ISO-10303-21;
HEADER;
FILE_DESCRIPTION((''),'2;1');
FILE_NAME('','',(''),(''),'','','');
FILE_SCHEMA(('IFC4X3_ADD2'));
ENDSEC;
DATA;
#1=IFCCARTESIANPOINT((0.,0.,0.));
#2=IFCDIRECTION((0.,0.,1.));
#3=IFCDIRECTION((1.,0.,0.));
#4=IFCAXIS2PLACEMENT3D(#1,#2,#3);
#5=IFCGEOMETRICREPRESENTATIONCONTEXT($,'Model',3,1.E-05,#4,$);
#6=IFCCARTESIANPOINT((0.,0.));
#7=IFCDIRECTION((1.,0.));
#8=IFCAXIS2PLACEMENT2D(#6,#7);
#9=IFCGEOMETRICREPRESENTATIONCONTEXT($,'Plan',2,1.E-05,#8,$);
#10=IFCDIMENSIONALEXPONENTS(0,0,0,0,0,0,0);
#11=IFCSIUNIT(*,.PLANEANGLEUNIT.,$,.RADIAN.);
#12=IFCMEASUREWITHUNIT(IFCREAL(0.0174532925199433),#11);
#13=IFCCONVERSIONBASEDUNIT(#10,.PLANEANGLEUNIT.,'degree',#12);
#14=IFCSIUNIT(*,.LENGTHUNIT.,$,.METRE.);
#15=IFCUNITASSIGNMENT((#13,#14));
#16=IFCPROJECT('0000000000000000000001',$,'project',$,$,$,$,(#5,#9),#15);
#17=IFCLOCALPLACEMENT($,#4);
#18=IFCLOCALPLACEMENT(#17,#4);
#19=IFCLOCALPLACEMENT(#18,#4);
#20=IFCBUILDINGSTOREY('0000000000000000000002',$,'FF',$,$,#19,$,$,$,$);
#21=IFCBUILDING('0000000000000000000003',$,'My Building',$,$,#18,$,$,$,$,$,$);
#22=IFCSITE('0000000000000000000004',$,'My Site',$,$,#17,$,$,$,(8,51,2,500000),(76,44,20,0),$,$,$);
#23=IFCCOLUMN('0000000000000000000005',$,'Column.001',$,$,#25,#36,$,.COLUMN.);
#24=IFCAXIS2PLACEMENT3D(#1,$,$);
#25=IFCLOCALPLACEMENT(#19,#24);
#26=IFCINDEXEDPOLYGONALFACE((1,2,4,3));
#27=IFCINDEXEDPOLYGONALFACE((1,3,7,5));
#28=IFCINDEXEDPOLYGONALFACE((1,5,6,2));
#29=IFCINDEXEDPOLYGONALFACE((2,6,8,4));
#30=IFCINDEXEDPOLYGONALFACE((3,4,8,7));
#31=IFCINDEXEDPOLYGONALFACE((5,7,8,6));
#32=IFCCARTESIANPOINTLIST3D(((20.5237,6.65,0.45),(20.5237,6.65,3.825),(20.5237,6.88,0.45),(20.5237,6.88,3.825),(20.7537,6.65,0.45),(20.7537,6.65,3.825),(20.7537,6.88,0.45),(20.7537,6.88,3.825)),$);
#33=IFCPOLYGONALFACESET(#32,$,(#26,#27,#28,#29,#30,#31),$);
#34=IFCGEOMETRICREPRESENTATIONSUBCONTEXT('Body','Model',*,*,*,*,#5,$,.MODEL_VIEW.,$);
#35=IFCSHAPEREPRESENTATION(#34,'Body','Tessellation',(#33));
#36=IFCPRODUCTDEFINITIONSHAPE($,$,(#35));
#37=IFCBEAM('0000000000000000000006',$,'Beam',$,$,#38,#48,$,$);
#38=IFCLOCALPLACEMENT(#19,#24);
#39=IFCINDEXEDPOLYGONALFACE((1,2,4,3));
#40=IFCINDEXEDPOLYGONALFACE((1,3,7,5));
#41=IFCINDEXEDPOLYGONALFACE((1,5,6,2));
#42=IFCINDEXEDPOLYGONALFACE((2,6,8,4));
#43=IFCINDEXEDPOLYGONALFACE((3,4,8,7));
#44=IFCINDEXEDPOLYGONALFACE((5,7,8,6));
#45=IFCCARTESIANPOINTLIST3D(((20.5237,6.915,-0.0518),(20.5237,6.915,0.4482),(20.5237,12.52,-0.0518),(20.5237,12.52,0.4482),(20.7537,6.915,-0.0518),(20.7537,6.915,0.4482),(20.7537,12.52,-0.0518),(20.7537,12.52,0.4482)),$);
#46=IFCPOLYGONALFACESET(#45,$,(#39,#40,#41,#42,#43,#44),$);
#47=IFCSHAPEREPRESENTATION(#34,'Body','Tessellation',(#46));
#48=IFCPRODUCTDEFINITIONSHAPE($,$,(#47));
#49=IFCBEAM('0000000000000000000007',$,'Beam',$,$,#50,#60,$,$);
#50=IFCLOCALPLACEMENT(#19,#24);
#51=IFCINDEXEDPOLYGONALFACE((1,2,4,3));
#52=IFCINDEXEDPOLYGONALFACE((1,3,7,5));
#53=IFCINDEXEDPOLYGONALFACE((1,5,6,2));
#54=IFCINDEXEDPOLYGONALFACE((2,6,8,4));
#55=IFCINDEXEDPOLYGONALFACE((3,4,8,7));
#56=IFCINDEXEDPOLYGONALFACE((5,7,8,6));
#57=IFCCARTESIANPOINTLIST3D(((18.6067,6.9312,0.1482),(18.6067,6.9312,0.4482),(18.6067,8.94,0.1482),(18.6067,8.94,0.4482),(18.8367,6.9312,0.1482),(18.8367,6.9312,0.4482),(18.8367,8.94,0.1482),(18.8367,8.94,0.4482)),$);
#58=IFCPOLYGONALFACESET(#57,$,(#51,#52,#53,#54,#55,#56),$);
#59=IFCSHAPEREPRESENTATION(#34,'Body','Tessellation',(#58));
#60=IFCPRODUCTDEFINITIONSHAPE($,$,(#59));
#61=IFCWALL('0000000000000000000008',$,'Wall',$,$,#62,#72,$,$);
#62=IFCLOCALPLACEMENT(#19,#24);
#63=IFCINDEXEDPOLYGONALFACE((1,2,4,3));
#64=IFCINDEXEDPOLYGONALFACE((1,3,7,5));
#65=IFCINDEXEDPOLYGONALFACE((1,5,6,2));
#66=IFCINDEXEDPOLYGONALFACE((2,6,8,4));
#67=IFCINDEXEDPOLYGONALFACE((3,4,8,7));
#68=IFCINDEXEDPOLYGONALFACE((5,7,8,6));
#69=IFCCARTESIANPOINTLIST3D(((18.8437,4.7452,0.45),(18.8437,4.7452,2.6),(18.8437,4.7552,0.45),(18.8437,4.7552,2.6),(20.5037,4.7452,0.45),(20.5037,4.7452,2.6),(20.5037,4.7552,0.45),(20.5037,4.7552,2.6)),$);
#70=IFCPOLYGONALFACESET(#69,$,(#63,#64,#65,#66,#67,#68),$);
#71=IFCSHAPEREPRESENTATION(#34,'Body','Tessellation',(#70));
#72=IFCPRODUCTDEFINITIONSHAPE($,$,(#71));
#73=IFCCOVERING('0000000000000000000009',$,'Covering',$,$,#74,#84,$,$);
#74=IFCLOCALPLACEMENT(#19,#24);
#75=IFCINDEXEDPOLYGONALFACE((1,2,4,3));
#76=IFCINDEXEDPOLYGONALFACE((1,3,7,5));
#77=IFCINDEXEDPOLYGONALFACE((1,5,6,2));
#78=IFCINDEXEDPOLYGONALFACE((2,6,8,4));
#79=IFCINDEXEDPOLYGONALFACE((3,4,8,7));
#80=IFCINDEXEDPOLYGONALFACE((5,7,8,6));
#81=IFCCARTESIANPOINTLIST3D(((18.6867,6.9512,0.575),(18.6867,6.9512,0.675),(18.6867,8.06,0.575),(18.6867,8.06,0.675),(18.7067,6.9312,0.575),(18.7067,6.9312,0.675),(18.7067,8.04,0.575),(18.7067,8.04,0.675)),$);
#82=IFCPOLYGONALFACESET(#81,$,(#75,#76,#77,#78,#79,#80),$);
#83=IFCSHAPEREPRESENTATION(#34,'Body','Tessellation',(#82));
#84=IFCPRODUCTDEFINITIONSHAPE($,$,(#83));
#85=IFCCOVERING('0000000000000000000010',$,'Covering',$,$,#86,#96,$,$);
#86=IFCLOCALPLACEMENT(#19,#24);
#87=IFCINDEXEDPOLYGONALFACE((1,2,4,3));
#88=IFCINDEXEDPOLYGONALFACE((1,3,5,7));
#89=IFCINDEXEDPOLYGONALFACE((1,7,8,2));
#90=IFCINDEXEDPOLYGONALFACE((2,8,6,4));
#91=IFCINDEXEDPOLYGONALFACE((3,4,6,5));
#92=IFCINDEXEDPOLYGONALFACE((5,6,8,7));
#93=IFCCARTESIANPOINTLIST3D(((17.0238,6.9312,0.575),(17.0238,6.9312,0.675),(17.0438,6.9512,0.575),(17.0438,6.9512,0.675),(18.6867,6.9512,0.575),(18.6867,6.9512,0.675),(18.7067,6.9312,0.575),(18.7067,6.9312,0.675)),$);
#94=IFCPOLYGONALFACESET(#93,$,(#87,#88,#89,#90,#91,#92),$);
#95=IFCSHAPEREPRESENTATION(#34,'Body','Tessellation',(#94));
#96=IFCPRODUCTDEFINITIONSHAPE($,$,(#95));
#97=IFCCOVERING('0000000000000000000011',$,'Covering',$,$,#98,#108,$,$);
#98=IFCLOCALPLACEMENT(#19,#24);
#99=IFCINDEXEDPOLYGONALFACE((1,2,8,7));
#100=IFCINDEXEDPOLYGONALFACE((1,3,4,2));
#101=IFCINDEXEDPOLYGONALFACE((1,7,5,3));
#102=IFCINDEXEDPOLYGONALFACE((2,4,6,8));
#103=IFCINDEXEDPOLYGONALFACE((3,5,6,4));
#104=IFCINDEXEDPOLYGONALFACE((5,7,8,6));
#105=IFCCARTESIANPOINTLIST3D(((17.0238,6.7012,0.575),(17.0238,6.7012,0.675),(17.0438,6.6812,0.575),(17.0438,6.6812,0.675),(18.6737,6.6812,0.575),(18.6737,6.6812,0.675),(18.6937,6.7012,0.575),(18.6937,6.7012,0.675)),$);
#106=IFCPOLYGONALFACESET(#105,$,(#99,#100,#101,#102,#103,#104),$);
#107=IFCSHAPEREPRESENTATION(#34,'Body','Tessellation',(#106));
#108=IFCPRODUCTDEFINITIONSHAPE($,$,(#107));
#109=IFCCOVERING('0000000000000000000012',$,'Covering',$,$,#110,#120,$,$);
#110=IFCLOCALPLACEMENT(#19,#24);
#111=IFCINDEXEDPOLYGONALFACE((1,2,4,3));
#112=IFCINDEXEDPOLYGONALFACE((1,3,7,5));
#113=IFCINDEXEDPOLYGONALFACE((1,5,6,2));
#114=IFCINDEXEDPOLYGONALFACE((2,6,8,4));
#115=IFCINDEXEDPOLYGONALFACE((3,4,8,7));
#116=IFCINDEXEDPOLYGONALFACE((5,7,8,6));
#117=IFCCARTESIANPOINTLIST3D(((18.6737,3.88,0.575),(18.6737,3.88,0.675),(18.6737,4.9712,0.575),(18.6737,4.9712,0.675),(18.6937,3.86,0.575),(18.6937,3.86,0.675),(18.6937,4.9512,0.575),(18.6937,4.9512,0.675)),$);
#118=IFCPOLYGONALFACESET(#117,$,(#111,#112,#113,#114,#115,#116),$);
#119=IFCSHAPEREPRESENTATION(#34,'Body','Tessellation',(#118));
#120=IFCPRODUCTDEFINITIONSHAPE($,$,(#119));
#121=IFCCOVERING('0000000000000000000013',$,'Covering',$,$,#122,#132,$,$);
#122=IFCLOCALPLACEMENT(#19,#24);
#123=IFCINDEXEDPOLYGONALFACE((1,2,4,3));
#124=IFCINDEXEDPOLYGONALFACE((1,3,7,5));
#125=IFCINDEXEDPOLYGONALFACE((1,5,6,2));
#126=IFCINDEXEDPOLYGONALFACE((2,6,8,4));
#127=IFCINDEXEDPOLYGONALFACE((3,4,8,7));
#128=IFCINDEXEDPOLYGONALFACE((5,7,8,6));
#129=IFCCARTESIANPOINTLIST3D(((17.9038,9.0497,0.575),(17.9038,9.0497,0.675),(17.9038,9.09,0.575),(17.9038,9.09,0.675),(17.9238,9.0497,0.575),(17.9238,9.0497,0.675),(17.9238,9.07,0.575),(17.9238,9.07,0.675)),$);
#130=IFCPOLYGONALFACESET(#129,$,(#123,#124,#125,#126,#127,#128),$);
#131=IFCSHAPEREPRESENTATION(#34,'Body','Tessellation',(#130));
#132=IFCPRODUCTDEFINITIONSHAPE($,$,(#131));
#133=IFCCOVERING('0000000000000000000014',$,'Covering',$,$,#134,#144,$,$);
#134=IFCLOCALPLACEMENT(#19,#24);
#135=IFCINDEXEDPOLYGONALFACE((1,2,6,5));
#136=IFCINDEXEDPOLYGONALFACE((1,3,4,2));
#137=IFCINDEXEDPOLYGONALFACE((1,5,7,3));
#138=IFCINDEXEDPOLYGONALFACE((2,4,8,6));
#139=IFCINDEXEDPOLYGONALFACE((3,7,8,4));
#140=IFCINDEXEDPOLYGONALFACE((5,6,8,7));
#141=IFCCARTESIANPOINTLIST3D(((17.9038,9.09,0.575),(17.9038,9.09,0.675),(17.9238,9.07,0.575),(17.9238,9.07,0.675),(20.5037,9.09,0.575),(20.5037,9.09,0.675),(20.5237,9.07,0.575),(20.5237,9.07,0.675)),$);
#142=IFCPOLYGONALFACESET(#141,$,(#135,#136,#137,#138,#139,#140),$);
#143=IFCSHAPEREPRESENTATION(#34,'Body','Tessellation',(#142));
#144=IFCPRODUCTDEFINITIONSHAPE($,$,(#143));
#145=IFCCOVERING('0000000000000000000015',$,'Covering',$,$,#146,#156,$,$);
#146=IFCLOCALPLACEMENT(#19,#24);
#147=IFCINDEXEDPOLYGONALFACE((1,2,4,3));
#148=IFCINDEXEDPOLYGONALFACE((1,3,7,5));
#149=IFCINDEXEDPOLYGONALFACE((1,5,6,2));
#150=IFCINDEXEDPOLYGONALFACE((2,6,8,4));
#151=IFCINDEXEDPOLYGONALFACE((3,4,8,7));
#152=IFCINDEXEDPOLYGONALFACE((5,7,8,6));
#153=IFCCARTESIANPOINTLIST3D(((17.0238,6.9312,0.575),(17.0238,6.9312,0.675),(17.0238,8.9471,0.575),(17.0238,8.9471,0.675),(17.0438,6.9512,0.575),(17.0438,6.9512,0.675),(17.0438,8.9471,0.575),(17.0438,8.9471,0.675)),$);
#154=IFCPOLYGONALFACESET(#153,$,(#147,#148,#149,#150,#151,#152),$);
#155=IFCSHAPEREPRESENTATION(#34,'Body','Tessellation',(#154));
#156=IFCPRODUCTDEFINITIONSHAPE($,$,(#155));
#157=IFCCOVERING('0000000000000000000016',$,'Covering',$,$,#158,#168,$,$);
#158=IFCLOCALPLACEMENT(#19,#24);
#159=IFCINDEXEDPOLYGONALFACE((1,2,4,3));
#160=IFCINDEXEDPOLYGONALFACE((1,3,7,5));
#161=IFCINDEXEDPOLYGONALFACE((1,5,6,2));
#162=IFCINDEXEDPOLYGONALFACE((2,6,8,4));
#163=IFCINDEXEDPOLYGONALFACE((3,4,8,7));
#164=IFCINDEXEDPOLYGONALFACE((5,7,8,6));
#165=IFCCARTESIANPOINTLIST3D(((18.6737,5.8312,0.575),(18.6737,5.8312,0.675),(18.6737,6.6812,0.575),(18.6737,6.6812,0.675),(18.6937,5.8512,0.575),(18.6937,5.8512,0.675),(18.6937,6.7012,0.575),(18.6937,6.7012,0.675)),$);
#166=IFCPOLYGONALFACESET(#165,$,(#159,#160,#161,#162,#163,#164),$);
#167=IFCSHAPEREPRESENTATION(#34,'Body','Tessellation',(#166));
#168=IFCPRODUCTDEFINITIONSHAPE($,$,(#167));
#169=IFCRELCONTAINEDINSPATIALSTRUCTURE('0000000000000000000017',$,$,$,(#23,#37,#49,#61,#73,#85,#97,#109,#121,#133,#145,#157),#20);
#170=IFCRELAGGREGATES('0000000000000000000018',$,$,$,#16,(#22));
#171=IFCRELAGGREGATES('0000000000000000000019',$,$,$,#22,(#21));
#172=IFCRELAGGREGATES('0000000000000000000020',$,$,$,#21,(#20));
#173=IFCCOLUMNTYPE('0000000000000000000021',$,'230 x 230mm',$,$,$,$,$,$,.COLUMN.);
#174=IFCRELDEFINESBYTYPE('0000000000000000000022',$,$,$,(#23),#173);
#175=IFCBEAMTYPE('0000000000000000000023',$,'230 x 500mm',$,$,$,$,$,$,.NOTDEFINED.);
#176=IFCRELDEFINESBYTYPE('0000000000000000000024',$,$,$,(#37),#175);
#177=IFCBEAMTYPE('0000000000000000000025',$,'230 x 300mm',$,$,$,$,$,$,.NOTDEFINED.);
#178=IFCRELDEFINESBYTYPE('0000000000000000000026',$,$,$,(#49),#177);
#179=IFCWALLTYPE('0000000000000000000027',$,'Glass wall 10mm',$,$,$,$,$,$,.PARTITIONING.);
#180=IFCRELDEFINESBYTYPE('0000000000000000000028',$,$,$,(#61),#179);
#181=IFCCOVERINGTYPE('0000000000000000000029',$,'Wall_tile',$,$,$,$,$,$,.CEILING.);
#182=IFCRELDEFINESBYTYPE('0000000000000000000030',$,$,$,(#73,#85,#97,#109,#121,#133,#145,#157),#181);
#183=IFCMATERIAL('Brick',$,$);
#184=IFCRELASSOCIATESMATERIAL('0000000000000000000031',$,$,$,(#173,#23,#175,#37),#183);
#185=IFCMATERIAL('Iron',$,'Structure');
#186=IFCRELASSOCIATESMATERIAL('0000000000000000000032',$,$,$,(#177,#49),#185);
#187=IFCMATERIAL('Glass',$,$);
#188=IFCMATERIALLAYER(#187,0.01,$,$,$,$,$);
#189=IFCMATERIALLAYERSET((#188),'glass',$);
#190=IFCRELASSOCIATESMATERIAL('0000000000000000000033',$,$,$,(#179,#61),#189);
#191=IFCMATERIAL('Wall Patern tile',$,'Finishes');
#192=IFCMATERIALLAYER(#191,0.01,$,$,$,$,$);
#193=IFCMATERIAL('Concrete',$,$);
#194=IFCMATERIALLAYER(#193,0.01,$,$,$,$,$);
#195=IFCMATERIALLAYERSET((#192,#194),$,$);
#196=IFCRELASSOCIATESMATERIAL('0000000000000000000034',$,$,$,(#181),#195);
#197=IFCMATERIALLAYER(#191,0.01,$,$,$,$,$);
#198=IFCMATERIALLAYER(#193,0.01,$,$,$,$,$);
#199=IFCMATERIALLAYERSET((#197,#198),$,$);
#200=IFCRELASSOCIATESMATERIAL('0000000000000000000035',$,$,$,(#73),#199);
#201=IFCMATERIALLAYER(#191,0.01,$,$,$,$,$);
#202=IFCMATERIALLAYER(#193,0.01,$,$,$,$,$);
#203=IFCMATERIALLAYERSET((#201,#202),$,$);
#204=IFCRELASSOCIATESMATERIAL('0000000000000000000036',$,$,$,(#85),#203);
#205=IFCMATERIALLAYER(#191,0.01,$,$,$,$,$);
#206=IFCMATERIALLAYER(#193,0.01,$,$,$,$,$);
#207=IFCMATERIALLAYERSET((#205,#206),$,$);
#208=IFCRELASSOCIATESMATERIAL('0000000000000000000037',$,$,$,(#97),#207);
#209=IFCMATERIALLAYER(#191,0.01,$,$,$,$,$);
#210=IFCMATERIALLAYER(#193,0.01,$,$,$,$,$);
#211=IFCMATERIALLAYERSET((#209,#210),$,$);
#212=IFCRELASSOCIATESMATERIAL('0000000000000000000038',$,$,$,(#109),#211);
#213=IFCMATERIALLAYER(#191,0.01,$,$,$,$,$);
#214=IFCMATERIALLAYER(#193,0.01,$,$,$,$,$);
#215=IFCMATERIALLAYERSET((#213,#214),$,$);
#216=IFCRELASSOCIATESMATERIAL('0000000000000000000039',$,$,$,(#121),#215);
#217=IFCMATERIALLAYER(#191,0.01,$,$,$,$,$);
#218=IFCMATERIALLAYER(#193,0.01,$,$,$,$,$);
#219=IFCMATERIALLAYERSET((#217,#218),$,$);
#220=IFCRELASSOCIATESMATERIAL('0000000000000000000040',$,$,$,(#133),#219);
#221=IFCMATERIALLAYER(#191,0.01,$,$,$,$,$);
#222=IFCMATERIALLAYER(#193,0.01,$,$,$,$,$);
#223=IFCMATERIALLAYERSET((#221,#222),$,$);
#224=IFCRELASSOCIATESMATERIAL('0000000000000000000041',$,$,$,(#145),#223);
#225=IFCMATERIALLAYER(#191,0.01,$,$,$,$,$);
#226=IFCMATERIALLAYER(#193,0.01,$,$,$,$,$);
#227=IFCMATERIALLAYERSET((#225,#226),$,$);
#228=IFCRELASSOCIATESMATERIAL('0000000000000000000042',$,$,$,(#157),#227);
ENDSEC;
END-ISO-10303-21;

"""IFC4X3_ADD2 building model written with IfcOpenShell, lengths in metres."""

from ifc_helpers import new_model, entity, si_unit, converted_unit, frame, origin_with_axes, origin_2d_with_axis, place, context, subcontext, project, spatial, line, indexed_curve, rectangle, outline, extrude, material, layer, layer_set, layer_usage, material_profile, profile_set, profile_usage, type_object, element, save


model = new_model("IFC4X3_ADD2")

# Units and contexts
model_context = context("Model", 3, precision=1e-05, world=origin_with_axes())
plan_context = context("Plan", 2, precision=1e-05, world=origin_2d_with_axis())
body_context_1 = subcontext(model_context, "Body", "Model", "MODEL_VIEW")
ifc_project = project(units=[converted_unit("PLANEANGLEUNIT", "degree", entity("IfcReal", 0.0174532925199433), si_unit("PLANEANGLEUNIT", "RADIAN"), dimensions=[0, 0, 0, 0, 0, 0, 0]), si_unit("LENGTHUNIT", "METRE")], contexts=[model_context, plan_context])

# Site, building, storey
site_placement = place(None, origin_with_axes())
site = spatial("IfcSite", under=ifc_project, at=site_placement, Name="My Site", RefLatitude=(8, 51, 2, 500000), RefLongitude=(76, 44, 20, 0))
building_placement = place(site_placement, origin_with_axes())
building = spatial("IfcBuilding", under=site, at=building_placement, Name="My Building")
storey_placement = place(building_placement, origin_with_axes())
storey = spatial("IfcBuildingStorey", under=building, at=storey_placement, Name="FF")

# Column
ifc_material_1 = material(Name="Brick")
ifc_material_profile_1 = material_profile(ifc_material_1, outline(indexed_curve([(-0.115, 0.115), (0.115, 0.115), (0.115, -0.115), (-0.115, -0.115), (-0.115, 0.115)])))
ifc_profile_set_1 = profile_set([ifc_material_profile_1])
ifc_profile_usage_1 = profile_usage(ifc_profile_set_1)
column_type = type_object("IfcColumnType", Name="230 x 230mm", PredefinedType="COLUMN", material=ifc_profile_set_1)
column_placement = place(storey_placement, frame((20.6387, 6.765, 0.45), z_axis=(0.0, 0.0, 1.0), x_axis=(1.0, 0.0, 0.0)))
element("IfcColumn", 1, at=column_placement, inside=storey, type_object=column_type, material=ifc_profile_usage_1, Name="Column.001", PredefinedType="COLUMN", context=body_context_1, shape_type="SweptSolid", body=[
    extrude(outline(indexed_curve([(-0.115, 0.115), (0.115, 0.115), (0.115, -0.115), (-0.115, -0.115), (-0.115, 0.115)])), origin_with_axes(), (0.0, 0.0, 1.0), 3.375),
])

# Beams
ifc_material_profile_2 = material_profile(ifc_material_1, rectangle(XDim=0.23, YDim=0.5))
ifc_profile_set_2 = profile_set([ifc_material_profile_2], Name="rcc")
ifc_profile_usage_2 = profile_usage(ifc_profile_set_2)
beam_type_1 = type_object("IfcBeamType", Name="230 x 500mm", PredefinedType="NOTDEFINED", material=ifc_profile_set_2)
beam_1_placement = place(storey_placement, frame((20.6387, 6.915, 0.1982), z_axis=(0.0, 1.0, 0.0), x_axis=(-1.0, 0.0, 0.0)))
element("IfcBeam", 2, at=beam_1_placement, inside=storey, type_object=beam_type_1, material=ifc_profile_usage_2, Name="Beam", context=body_context_1, shape_type="SweptSolid", body=[
    extrude(rectangle(XDim=0.23, YDim=0.5), origin_with_axes(), (0.0, 0.0, 1.0), 5.605),
])
ifc_material_2 = material(Name="Iron", Category="Structure")
ifc_material_profile_3 = material_profile(ifc_material_2, rectangle(XDim=0.23, YDim=0.3))
ifc_profile_set_3 = profile_set([ifc_material_profile_3], Name="blank")
ifc_profile_usage_3 = profile_usage(ifc_profile_set_3)
beam_type_2 = type_object("IfcBeamType", Name="230 x 300mm", PredefinedType="NOTDEFINED", material=ifc_profile_set_3)
beam_2_placement = place(storey_placement, frame((18.7217, 6.9312, 0.2982), z_axis=(0.0, 1.0, 0.0), x_axis=(-1.0, 0.0, 0.0)))
element("IfcBeam", 3, at=beam_2_placement, inside=storey, type_object=beam_type_2, material=ifc_profile_usage_3, Name="Beam", context=body_context_1, shape_type="SweptSolid", body=[
    extrude(rectangle(XDim=0.23, YDim=0.3), origin_with_axes(), (0.0, 0.0, 1.0), 2.0088),
])

# Shared definitions
ifc_material_3 = material(Name="Glass")

# Wall
ifc_layer_1 = layer(ifc_material_3, 0.01)
ifc_layer_set_1 = layer_set([ifc_layer_1], Name="glass")
ifc_layer_usage_1 = layer_usage(ifc_layer_set_1, "AXIS2", "POSITIVE", 0.0)
wall_type_1 = type_object("IfcWallType", Name="Glass wall 10mm", PredefinedType="PARTITIONING", material=ifc_layer_set_1)
wall_1_placement = place(storey_placement, frame((20.5037, 4.7552, 0.45), z_axis=(0.0, 0.0, 1.0), x_axis=(-1.0, 0.0, 0.0)))
element("IfcWall", 4, at=wall_1_placement, inside=storey, type_object=wall_type_1, material=ifc_layer_usage_1, Name="Wall", context=body_context_1, shape_type="SweptSolid", body=[
    extrude(outline(indexed_curve([(0.0, 0.0), (0.0, 0.01), (1.66, 0.01), (1.66, 0.0)], segments=[line(1, 2, 3, 4, 1)])), origin_with_axes(), (0.0, 0.0, 1.0), 2.15),
])

# Coverings
ifc_material_4 = material(Name="Wall Patern tile", Category="Finishes")
ifc_layer_2 = layer(ifc_material_4, 0.01)
ifc_material_5 = material(Name="Concrete")
ifc_layer_3 = layer(ifc_material_5, 0.01)
ifc_layer_set_2 = layer_set([ifc_layer_2, ifc_layer_3])
ifc_layer_usage_2 = layer_usage(ifc_layer_set_2, "AXIS2", "POSITIVE", 0.0)
ifc_layer_4 = layer(ifc_material_4, 0.01)
ifc_layer_5 = layer(ifc_material_5, 0.01)
ifc_layer_set_3 = layer_set([ifc_layer_4, ifc_layer_5])
covering_type_1 = type_object("IfcCoveringType", Name="Wall_tile", PredefinedType="CEILING", material=ifc_layer_set_3)
covering_1_placement = place(storey_placement, frame((18.6867, 8.04, 0.575), z_axis=(0.0, 0.0, 1.0), x_axis=(0.0, -1.0, 0.0)))
element("IfcCovering", 5, at=covering_1_placement, inside=storey, type_object=covering_type_1, material=ifc_layer_usage_2, Name="Covering", context=body_context_1, shape_type="SweptSolid", body=[
    extrude(outline(indexed_curve([(-0.02, 0.0), (0.0, 0.02), (1.1088, 0.02), (1.0888, 0.0)], segments=[line(1, 2, 3, 4, 1)])), origin_with_axes(), (0.0, 0.0, 1.0), 0.1),
])
ifc_layer_6 = layer(ifc_material_4, 0.01)
ifc_layer_7 = layer(ifc_material_5, 0.01)
ifc_layer_set_4 = layer_set([ifc_layer_6, ifc_layer_7])
ifc_layer_usage_3 = layer_usage(ifc_layer_set_4, "AXIS2", "POSITIVE", 0.0)
covering_2_placement = place(storey_placement, frame((18.6867, 6.9512, 0.575), z_axis=(0.0, 0.0, 1.0), x_axis=(-1.0, 0.0, 0.0)))
element("IfcCovering", 6, at=covering_2_placement, inside=storey, type_object=covering_type_1, material=ifc_layer_usage_3, Name="Covering", context=body_context_1, shape_type="SweptSolid", body=[
    extrude(outline(indexed_curve([(0.0, 0.0), (-0.02, 0.02), (1.6629, 0.02), (1.6429, 0.0)], segments=[line(1, 2, 3, 4, 1)])), origin_with_axes(), (0.0, 0.0, 1.0), 0.1),
])
ifc_layer_8 = layer(ifc_material_4, 0.01)
ifc_layer_9 = layer(ifc_material_5, 0.01)
ifc_layer_set_5 = layer_set([ifc_layer_8, ifc_layer_9])
ifc_layer_usage_4 = layer_usage(ifc_layer_set_5, "AXIS2", "NEGATIVE", 0.0)
covering_3_placement = place(storey_placement, frame((18.6737, 6.6812, 0.575), z_axis=(0.0, 0.0, 1.0), x_axis=(-1.0, 0.0, 0.0)))
element("IfcCovering", 7, at=covering_3_placement, inside=storey, type_object=covering_type_1, material=ifc_layer_usage_4, Name="Covering", context=body_context_1, shape_type="SweptSolid", body=[
    extrude(outline(indexed_curve([(-0.02, -0.02), (0.0, 0.0), (1.6299, 0.0), (1.6499, -0.02)], segments=[line(1, 2, 3, 4, 1)])), origin_with_axes(), (0.0, 0.0, 1.0), 0.1),
])
ifc_layer_10 = layer(ifc_material_4, 0.01)
ifc_layer_11 = layer(ifc_material_5, 0.01)
ifc_layer_set_6 = layer_set([ifc_layer_10, ifc_layer_11])
ifc_layer_usage_5 = layer_usage(ifc_layer_set_6, "AXIS2", "POSITIVE", 0.0)
covering_4_placement = place(storey_placement, frame((18.6737, 4.9712, 0.575), z_axis=(0.0, 0.0, 1.0), x_axis=(0.0, -1.0, 0.0)))
element("IfcCovering", 8, at=covering_4_placement, inside=storey, type_object=covering_type_1, material=ifc_layer_usage_5, Name="Covering", context=body_context_1, shape_type="SweptSolid", body=[
    extrude(outline(indexed_curve([(0.0, 0.0), (0.02, 0.02), (1.1112, 0.02), (1.0912, 0.0)], segments=[line(1, 2, 3, 4, 1)])), origin_with_axes(), (0.0, 0.0, 1.0), 0.1),
])
ifc_layer_12 = layer(ifc_material_4, 0.01)
ifc_layer_13 = layer(ifc_material_5, 0.01)
ifc_layer_set_7 = layer_set([ifc_layer_12, ifc_layer_13])
ifc_layer_usage_6 = layer_usage(ifc_layer_set_7, "AXIS2", "POSITIVE", 0.0)
covering_5_placement = place(storey_placement, frame((17.9038, 9.09, 0.575), z_axis=(0.0, 0.0, 1.0), x_axis=(0.0, -1.0, 0.0)))
element("IfcCovering", 9, at=covering_5_placement, inside=storey, type_object=covering_type_1, material=ifc_layer_usage_6, Name="Covering", context=body_context_1, shape_type="SweptSolid", body=[
    extrude(outline(indexed_curve([(0.0, 0.0), (0.02, 0.02), (0.0403, 0.02), (0.0403, 0.0)], segments=[line(1, 2, 3, 4, 1)])), origin_with_axes(), (0.0, 0.0, 1.0), 0.1),
])
ifc_layer_14 = layer(ifc_material_4, 0.01)
ifc_layer_15 = layer(ifc_material_5, 0.01)
ifc_layer_set_8 = layer_set([ifc_layer_14, ifc_layer_15])
ifc_layer_usage_7 = layer_usage(ifc_layer_set_8, "AXIS2", "NEGATIVE", 0.0)
covering_6_placement = place(storey_placement, frame((17.9038, 9.09, 0.575), z_axis=(0.0, 0.0, 1.0), x_axis=(1.0, 0.0, 0.0)))
element("IfcCovering", 10, at=covering_6_placement, inside=storey, type_object=covering_type_1, material=ifc_layer_usage_7, Name="Covering", context=body_context_1, shape_type="SweptSolid", body=[
    extrude(outline(indexed_curve([(0.02, -0.02), (0.0, 0.0), (2.5999, 0.0), (2.6199, -0.02)], segments=[line(1, 2, 3, 4, 1)])), origin_with_axes(), (0.0, 0.0, 1.0), 0.1),
])
ifc_layer_16 = layer(ifc_material_4, 0.01)
ifc_layer_17 = layer(ifc_material_5, 0.01)
ifc_layer_set_9 = layer_set([ifc_layer_16, ifc_layer_17])
ifc_layer_usage_8 = layer_usage(ifc_layer_set_9, "AXIS2", "NEGATIVE", 0.0)
covering_7_placement = place(storey_placement, frame((17.0438, 8.9471, 0.575), z_axis=(0.0, 0.0, 1.0), x_axis=(0.0, -1.0, 0.0)))
element("IfcCovering", 11, at=covering_7_placement, inside=storey, type_object=covering_type_1, material=ifc_layer_usage_8, Name="Covering", context=body_context_1, shape_type="SweptSolid", body=[
    extrude(outline(indexed_curve([(0.0, -0.02), (0.0, 0.0), (1.9959, 0.0), (2.0159, -0.02)], segments=[line(1, 2, 3, 4, 1)])), origin_with_axes(), (0.0, 0.0, 1.0), 0.1),
])
ifc_layer_18 = layer(ifc_material_4, 0.01)
ifc_layer_19 = layer(ifc_material_5, 0.01)
ifc_layer_set_10 = layer_set([ifc_layer_18, ifc_layer_19])
ifc_layer_usage_9 = layer_usage(ifc_layer_set_10, "AXIS2", "POSITIVE", 0.0)
covering_8_placement = place(storey_placement, frame((18.6737, 6.6812, 0.575), z_axis=(0.0, 0.0, 1.0), x_axis=(0.0, -1.0, 0.0)))
element("IfcCovering", 12, at=covering_8_placement, inside=storey, type_object=covering_type_1, material=ifc_layer_usage_9, Name="Covering", context=body_context_1, shape_type="SweptSolid", body=[
    extrude(outline(indexed_curve([(0.0, 0.0), (-0.02, 0.02), (0.83, 0.02), (0.85, 0.0)], segments=[line(1, 2, 3, 4, 1)])), origin_with_axes(), (0.0, 0.0, 1.0), 0.1),
])

save(model, "model.ifc")
